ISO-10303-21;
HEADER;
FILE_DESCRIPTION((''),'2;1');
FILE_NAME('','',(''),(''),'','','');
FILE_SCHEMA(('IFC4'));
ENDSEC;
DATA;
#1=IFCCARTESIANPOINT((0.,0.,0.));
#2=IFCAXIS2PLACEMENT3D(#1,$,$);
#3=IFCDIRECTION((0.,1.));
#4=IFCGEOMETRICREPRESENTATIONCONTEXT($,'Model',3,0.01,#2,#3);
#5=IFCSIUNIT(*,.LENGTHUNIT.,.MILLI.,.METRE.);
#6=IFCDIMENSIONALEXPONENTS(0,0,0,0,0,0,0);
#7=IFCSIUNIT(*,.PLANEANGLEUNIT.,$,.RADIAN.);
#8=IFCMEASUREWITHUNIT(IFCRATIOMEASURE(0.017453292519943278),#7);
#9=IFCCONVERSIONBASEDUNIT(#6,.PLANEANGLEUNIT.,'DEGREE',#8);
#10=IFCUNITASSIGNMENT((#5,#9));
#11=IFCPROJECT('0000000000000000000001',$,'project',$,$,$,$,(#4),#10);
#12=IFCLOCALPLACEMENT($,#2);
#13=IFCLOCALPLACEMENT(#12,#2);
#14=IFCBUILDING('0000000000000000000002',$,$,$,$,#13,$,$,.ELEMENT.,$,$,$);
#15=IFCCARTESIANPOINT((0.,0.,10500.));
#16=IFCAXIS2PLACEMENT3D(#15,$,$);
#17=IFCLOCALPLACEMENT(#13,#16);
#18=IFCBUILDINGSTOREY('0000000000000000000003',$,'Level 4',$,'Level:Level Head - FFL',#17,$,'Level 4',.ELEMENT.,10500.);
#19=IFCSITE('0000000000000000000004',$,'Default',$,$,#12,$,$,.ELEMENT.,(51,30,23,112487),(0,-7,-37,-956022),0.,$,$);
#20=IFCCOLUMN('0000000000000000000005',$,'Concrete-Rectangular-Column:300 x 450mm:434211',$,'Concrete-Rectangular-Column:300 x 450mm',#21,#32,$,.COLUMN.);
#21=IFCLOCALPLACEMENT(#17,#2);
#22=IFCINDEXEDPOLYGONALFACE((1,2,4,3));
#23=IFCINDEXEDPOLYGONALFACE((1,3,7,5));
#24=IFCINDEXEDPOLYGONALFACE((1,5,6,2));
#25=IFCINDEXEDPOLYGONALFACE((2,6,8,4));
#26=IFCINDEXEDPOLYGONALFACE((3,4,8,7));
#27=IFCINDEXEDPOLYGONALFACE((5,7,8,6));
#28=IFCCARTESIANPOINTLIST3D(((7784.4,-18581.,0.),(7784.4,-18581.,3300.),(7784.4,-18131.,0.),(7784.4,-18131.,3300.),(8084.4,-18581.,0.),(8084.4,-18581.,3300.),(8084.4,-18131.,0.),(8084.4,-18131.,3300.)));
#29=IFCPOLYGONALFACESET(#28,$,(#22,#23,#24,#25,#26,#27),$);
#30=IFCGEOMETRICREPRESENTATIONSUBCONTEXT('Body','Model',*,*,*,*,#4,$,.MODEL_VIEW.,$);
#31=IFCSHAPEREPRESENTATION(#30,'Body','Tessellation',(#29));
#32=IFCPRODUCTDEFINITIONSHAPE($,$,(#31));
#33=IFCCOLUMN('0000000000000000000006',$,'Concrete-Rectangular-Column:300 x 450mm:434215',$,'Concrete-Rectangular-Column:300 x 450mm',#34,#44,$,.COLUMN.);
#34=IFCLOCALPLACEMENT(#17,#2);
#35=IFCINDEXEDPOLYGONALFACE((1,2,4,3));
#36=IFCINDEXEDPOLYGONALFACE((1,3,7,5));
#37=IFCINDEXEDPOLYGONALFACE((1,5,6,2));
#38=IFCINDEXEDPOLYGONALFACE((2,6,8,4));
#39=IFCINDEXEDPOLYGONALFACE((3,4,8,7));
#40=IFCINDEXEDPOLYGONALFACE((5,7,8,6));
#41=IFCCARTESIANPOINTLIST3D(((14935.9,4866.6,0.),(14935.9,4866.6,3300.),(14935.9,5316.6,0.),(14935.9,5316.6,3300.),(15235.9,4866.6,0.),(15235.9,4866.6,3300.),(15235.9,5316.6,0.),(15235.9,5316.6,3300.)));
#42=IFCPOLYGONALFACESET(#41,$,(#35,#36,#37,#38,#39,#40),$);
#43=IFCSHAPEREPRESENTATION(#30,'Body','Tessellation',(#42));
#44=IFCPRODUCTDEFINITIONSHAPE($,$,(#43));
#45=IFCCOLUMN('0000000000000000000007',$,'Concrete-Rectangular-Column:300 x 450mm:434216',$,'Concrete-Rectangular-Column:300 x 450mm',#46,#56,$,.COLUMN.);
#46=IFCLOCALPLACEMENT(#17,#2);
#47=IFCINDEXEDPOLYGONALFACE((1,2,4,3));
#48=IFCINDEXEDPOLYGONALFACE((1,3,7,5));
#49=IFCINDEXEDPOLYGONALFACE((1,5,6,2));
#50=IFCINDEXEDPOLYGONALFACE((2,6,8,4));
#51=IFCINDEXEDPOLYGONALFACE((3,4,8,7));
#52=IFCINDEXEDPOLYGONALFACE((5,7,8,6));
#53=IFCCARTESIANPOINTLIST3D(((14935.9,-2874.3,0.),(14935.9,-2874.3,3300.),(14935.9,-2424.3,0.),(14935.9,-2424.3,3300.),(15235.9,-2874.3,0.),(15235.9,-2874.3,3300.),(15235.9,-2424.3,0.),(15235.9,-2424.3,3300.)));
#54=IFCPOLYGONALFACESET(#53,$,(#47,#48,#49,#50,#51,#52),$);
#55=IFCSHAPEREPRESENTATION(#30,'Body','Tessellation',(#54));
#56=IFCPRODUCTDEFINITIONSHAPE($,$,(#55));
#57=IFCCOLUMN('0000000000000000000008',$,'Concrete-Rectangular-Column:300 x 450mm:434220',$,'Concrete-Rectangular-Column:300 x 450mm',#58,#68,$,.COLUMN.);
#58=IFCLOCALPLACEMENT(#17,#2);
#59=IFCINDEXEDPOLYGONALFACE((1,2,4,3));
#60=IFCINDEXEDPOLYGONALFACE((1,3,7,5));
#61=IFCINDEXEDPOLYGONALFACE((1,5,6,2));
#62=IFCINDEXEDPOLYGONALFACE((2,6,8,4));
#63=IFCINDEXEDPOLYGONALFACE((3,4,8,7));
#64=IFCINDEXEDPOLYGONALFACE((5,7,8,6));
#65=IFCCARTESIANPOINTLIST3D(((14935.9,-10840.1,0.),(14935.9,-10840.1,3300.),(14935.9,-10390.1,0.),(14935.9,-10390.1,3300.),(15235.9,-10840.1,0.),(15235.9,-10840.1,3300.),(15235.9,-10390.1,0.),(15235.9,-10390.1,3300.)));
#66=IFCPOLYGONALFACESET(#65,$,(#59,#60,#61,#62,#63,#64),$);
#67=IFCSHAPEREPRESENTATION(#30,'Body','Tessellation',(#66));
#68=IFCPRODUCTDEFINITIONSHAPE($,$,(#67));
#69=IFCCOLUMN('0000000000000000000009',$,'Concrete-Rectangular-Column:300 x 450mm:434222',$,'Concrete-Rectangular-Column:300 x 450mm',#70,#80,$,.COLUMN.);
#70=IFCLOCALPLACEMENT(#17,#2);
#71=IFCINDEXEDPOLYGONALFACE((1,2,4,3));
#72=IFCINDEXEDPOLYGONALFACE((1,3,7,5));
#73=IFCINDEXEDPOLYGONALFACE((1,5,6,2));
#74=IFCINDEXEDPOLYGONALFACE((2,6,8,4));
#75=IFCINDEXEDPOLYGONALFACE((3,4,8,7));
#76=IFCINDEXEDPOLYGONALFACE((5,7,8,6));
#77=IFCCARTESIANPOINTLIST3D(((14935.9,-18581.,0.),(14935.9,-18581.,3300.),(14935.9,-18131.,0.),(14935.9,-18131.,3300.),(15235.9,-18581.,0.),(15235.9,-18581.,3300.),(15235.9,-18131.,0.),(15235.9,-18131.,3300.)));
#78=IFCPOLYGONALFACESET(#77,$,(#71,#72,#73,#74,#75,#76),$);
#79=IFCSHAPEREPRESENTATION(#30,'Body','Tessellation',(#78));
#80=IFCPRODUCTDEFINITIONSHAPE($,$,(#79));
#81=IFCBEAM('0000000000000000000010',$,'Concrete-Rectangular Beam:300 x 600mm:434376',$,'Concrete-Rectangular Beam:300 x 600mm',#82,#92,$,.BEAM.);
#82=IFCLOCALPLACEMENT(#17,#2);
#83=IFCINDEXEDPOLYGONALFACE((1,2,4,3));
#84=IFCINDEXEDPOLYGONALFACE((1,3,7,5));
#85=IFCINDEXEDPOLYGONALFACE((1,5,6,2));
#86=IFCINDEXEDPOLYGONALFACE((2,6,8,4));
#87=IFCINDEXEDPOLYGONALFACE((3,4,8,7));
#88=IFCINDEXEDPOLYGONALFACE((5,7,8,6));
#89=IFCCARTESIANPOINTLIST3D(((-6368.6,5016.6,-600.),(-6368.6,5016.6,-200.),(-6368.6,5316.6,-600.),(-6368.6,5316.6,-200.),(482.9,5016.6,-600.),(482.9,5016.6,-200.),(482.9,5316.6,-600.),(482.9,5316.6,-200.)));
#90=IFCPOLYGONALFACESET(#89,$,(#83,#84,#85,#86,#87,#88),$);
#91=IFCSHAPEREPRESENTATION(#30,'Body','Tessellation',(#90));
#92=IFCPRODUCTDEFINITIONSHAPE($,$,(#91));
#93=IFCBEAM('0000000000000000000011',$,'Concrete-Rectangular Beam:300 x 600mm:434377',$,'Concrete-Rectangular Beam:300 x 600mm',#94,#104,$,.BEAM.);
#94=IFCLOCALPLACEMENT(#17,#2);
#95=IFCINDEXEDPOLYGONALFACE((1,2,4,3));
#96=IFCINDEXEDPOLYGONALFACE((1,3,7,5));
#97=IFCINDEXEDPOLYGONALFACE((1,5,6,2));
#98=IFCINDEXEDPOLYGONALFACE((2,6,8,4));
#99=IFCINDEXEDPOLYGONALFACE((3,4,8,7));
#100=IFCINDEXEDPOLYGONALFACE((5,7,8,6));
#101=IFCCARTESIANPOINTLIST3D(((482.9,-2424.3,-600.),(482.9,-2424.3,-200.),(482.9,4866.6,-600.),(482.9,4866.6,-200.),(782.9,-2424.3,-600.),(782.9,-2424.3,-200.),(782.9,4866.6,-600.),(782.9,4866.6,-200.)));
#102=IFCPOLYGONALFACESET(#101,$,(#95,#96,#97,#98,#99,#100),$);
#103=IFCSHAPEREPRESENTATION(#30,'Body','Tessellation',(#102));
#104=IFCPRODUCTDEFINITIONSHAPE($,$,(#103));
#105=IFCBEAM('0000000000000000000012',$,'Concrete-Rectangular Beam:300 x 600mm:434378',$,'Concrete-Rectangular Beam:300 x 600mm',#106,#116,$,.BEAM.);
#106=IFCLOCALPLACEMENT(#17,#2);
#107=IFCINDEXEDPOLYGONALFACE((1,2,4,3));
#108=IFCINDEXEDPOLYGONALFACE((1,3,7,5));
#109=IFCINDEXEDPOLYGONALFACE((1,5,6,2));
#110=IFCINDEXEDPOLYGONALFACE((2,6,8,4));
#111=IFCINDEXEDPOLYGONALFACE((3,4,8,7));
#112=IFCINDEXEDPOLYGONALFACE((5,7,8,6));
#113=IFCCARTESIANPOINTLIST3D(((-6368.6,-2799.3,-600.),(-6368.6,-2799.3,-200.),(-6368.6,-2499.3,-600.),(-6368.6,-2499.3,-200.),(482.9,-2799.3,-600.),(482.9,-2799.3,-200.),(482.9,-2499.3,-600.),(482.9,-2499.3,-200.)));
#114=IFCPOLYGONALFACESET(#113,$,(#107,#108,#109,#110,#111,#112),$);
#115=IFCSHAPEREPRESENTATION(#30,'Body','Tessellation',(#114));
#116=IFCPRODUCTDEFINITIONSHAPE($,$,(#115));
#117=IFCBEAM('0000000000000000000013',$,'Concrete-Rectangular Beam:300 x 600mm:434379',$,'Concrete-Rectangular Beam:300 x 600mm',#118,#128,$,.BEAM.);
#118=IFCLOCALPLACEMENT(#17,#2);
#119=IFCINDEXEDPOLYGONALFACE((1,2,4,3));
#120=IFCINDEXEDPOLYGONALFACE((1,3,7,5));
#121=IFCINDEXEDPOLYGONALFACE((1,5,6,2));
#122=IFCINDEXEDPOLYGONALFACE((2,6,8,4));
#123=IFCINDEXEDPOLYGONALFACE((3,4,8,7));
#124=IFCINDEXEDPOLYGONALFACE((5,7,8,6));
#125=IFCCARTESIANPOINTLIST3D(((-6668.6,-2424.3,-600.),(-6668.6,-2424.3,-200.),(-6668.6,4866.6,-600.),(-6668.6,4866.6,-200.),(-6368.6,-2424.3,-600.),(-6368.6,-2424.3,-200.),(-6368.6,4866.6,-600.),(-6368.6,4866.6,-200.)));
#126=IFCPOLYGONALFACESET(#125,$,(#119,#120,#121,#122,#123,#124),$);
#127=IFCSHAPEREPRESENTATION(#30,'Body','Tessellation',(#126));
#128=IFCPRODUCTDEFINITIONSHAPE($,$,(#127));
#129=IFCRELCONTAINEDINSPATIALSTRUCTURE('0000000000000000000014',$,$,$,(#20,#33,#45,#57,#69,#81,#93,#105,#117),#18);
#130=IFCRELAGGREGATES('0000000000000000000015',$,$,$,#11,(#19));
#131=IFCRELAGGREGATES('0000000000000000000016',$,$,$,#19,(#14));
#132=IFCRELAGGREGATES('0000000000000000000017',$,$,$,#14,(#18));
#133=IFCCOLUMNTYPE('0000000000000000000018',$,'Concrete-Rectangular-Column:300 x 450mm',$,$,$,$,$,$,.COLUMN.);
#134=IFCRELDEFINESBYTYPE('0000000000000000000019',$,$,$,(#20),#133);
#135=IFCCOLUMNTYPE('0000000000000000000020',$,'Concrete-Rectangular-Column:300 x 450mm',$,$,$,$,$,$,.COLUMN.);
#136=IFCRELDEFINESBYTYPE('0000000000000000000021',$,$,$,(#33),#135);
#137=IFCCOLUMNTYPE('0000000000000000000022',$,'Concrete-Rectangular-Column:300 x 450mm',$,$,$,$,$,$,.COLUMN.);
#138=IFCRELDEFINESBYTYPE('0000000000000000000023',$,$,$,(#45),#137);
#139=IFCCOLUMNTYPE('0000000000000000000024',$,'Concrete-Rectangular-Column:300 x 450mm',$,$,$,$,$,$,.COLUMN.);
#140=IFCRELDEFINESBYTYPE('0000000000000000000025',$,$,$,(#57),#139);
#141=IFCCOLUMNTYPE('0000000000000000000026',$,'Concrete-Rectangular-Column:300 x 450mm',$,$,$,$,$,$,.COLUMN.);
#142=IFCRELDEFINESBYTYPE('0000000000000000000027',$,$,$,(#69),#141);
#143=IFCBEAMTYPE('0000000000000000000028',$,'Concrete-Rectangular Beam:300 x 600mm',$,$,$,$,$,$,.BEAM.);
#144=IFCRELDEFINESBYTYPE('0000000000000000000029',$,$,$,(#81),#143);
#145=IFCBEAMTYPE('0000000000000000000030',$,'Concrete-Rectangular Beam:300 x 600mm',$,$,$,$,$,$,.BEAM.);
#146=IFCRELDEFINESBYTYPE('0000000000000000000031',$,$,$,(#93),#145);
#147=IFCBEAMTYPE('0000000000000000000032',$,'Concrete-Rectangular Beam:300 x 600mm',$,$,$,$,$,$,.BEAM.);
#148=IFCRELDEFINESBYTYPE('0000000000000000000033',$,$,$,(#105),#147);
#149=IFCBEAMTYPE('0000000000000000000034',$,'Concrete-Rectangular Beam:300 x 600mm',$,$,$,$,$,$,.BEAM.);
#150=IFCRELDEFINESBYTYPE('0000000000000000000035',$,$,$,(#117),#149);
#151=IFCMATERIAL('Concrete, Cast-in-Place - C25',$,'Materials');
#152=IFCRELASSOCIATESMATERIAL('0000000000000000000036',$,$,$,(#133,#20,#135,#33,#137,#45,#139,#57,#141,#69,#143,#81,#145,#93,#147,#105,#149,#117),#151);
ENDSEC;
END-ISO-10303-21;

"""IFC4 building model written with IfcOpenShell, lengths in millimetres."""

from ifc_helpers import new_model, entity, si_unit, converted_unit, direction, frame, origin, place, context, subcontext, project, spatial, indexed_curve, outline, extrude, source, transform, mapped, material, type_object, type_shapes, element, save


model = new_model("IFC4")

# Units and contexts
model_context = context("Model", 3, precision=0.01, world=origin(), true_north=direction((0.0, 1.0)))
body_context = subcontext(model_context, "Body", "Model", "MODEL_VIEW")
ifc_project = project(units=[si_unit("LENGTHUNIT", "METRE", prefix="MILLI"), converted_unit("PLANEANGLEUNIT", "DEGREE", entity("IfcRatioMeasure", 0.017453292519943278), si_unit("PLANEANGLEUNIT", "RADIAN"), dimensions=[0, 0, 0, 0, 0, 0, 0])], contexts=[model_context])

# Site, building, storey
site_placement = place(None, origin())
site = spatial("IfcSite", under=ifc_project, at=site_placement, Name="Default", CompositionType="ELEMENT", RefLatitude=(51, 30, 23, 112487), RefLongitude=(0, -7, -37, -956022), RefElevation=0.0)
building_placement = place(site_placement, origin())
building = spatial("IfcBuilding", under=site, at=building_placement, CompositionType="ELEMENT")
storey_placement = place(building_placement, frame((0.0, 0.0, 10500.0)))
storey = spatial("IfcBuildingStorey", under=building, at=storey_placement, Name="Level 4", ObjectType="Level:Level Head - FFL", LongName="Level 4", CompositionType="ELEMENT", Elevation=10500.0)

# Columns
ifc_material = material(Name="Concrete, Cast-in-Place - C25", Category="Materials")
column_type_1 = type_object("IfcColumnType", Name="Concrete-Rectangular-Column:300 x 450mm", PredefinedType="COLUMN", material=ifc_material)
shared_shape_1 = source(origin(), body_context, "Body", "SweptSolid", [
    extrude(outline(indexed_curve([(-225.0, -150.0), (225.0, -150.0), (225.0, 150.0), (-225.0, 150.0), (-225.0, -150.0)], self_intersect=False)), frame((7934.4, -18356.0, 10500.0), z_axis=(0.0, 0.0, 1.0), x_axis=(0.0, -1.0, 0.0)), (0.0, 0.0, 1.0), 3300.0),
])
type_shapes(column_type_1, [shared_shape_1])
column_1_placement = place(storey_placement, frame((0.0, 0.0, -10500.0)))
element("IfcColumn", 1, at=column_1_placement, inside=storey, type_object=column_type_1, material=ifc_material, Name="Concrete-Rectangular-Column:300 x 450mm:434211", ObjectType="Concrete-Rectangular-Column:300 x 450mm", PredefinedType="COLUMN", context=body_context, shape_type="MappedRepresentation", body=[
    mapped(shared_shape_1, transform((0.0, 0.0, 0.0), scale=1.0)),
])
column_type_2 = type_object("IfcColumnType", Name="Concrete-Rectangular-Column:300 x 450mm", PredefinedType="COLUMN", material=ifc_material)
shared_shape_2 = source(origin(), body_context, "Body", "SweptSolid", [
    extrude(outline(indexed_curve([(-225.0, -150.0), (225.0, -150.0), (225.0, 150.0), (-225.0, 150.0), (-225.0, -150.0)], self_intersect=False)), frame((15085.9, 5091.6, 10500.0), z_axis=(0.0, 0.0, 1.0), x_axis=(0.0, -1.0, 0.0)), (0.0, 0.0, 1.0), 3300.0),
])
type_shapes(column_type_2, [shared_shape_2])
column_2_placement = place(storey_placement, frame((0.0, 0.0, -10500.0)))
element("IfcColumn", 2, at=column_2_placement, inside=storey, type_object=column_type_2, material=ifc_material, Name="Concrete-Rectangular-Column:300 x 450mm:434215", ObjectType="Concrete-Rectangular-Column:300 x 450mm", PredefinedType="COLUMN", context=body_context, shape_type="MappedRepresentation", body=[
    mapped(shared_shape_2, transform((0.0, 0.0, 0.0), scale=1.0)),
])
column_type_3 = type_object("IfcColumnType", Name="Concrete-Rectangular-Column:300 x 450mm", PredefinedType="COLUMN", material=ifc_material)
shared_shape_3 = source(origin(), body_context, "Body", "SweptSolid", [
    extrude(outline(indexed_curve([(-225.0, -150.0), (225.0, -150.0), (225.0, 150.0), (-225.0, 150.0), (-225.0, -150.0)], self_intersect=False)), frame((15085.9, -2649.3, 10500.0), z_axis=(0.0, 0.0, 1.0), x_axis=(0.0, -1.0, 0.0)), (0.0, 0.0, 1.0), 3300.0),
])
type_shapes(column_type_3, [shared_shape_3])
column_3_placement = place(storey_placement, frame((0.0, 0.0, -10500.0)))
element("IfcColumn", 3, at=column_3_placement, inside=storey, type_object=column_type_3, material=ifc_material, Name="Concrete-Rectangular-Column:300 x 450mm:434216", ObjectType="Concrete-Rectangular-Column:300 x 450mm", PredefinedType="COLUMN", context=body_context, shape_type="MappedRepresentation", body=[
    mapped(shared_shape_3, transform((0.0, 0.0, 0.0), scale=1.0)),
])
column_type_4 = type_object("IfcColumnType", Name="Concrete-Rectangular-Column:300 x 450mm", PredefinedType="COLUMN", material=ifc_material)
shared_shape_4 = source(origin(), body_context, "Body", "SweptSolid", [
    extrude(outline(indexed_curve([(-225.0, -150.0), (225.0, -150.0), (225.0, 150.0), (-225.0, 150.0), (-225.0, -150.0)], self_intersect=False)), frame((15085.9, -10615.1, 10500.0), z_axis=(0.0, 0.0, 1.0), x_axis=(0.0, -1.0, 0.0)), (0.0, 0.0, 1.0), 3300.0),
])
type_shapes(column_type_4, [shared_shape_4])
column_4_placement = place(storey_placement, frame((0.0, 0.0, -10500.0)))
element("IfcColumn", 4, at=column_4_placement, inside=storey, type_object=column_type_4, material=ifc_material, Name="Concrete-Rectangular-Column:300 x 450mm:434220", ObjectType="Concrete-Rectangular-Column:300 x 450mm", PredefinedType="COLUMN", context=body_context, shape_type="MappedRepresentation", body=[
    mapped(shared_shape_4, transform((0.0, 0.0, 0.0), scale=1.0)),
])
column_type_5 = type_object("IfcColumnType", Name="Concrete-Rectangular-Column:300 x 450mm", PredefinedType="COLUMN", material=ifc_material)
shared_shape_5 = source(origin(), body_context, "Body", "SweptSolid", [
    extrude(outline(indexed_curve([(-225.0, -150.0), (225.0, -150.0), (225.0, 150.0), (-225.0, 150.0), (-225.0, -150.0)], self_intersect=False)), frame((15085.9, -18356.0, 10500.0), z_axis=(0.0, 0.0, 1.0), x_axis=(0.0, -1.0, 0.0)), (0.0, 0.0, 1.0), 3300.0),
])
type_shapes(column_type_5, [shared_shape_5])
column_5_placement = place(storey_placement, frame((0.0, 0.0, -10500.0)))
element("IfcColumn", 5, at=column_5_placement, inside=storey, type_object=column_type_5, material=ifc_material, Name="Concrete-Rectangular-Column:300 x 450mm:434222", ObjectType="Concrete-Rectangular-Column:300 x 450mm", PredefinedType="COLUMN", context=body_context, shape_type="MappedRepresentation", body=[
    mapped(shared_shape_5, transform((0.0, 0.0, 0.0), scale=1.0)),
])

# Beams
beam_type_1 = type_object("IfcBeamType", Name="Concrete-Rectangular Beam:300 x 600mm", PredefinedType="BEAM", material=ifc_material)
shared_shape_6 = source(origin(), body_context, "Body", "SweptSolid", [
    extrude(outline(indexed_curve([(-200.0, -150.0), (200.0, -150.0), (200.0, 150.0), (-200.0, 150.0), (-200.0, -150.0)], self_intersect=False)), frame((-6368.6, 5166.6, 10100.0), z_axis=(1.0, 0.0, 0.0), x_axis=(0.0, 0.0, -1.0)), (0.0, 0.0, 1.0), 6851.5),
])
type_shapes(beam_type_1, [shared_shape_6])
beam_1_placement = place(storey_placement, frame((0.0, 0.0, -10500.0)))
element("IfcBeam", 6, at=beam_1_placement, inside=storey, type_object=beam_type_1, material=ifc_material, Name="Concrete-Rectangular Beam:300 x 600mm:434376", ObjectType="Concrete-Rectangular Beam:300 x 600mm", PredefinedType="BEAM", context=body_context, shape_type="MappedRepresentation", body=[
    mapped(shared_shape_6, transform((0.0, 0.0, 0.0), scale=1.0)),
])
beam_type_2 = type_object("IfcBeamType", Name="Concrete-Rectangular Beam:300 x 600mm", PredefinedType="BEAM", material=ifc_material)
shared_shape_7 = source(origin(), body_context, "Body", "SweptSolid", [
    extrude(outline(indexed_curve([(-150.0, -200.0), (150.0, -200.0), (150.0, 200.0), (-150.0, 200.0), (-150.0, -200.0)], self_intersect=False)), frame((632.9, 4866.6, 10100.0), z_axis=(0.0, -1.0, 0.0), x_axis=(-1.0, 0.0, 0.0)), (0.0, 0.0, 1.0), 7290.9),
])
type_shapes(beam_type_2, [shared_shape_7])
beam_2_placement = place(storey_placement, frame((0.0, 0.0, -10500.0)))
element("IfcBeam", 7, at=beam_2_placement, inside=storey, type_object=beam_type_2, material=ifc_material, Name="Concrete-Rectangular Beam:300 x 600mm:434377", ObjectType="Concrete-Rectangular Beam:300 x 600mm", PredefinedType="BEAM", context=body_context, shape_type="MappedRepresentation", body=[
    mapped(shared_shape_7, transform((0.0, 0.0, 0.0), scale=1.0)),
])
beam_type_3 = type_object("IfcBeamType", Name="Concrete-Rectangular Beam:300 x 600mm", PredefinedType="BEAM", material=ifc_material)
shared_shape_8 = source(origin(), body_context, "Body", "SweptSolid", [
    extrude(outline(indexed_curve([(-200.0, -150.0), (200.0, -150.0), (200.0, 150.0), (-200.0, 150.0), (-200.0, -150.0)], self_intersect=False)), frame((482.9, -2649.3, 10100.0), z_axis=(-1.0, 0.0, 0.0), x_axis=(0.0, 0.0, -1.0)), (0.0, 0.0, 1.0), 6851.5),
])
type_shapes(beam_type_3, [shared_shape_8])
beam_3_placement = place(storey_placement, frame((0.0, 0.0, -10500.0)))
element("IfcBeam", 8, at=beam_3_placement, inside=storey, type_object=beam_type_3, material=ifc_material, Name="Concrete-Rectangular Beam:300 x 600mm:434378", ObjectType="Concrete-Rectangular Beam:300 x 600mm", PredefinedType="BEAM", context=body_context, shape_type="MappedRepresentation", body=[
    mapped(shared_shape_8, transform((0.0, 0.0, 0.0), scale=1.0)),
])
beam_type_4 = type_object("IfcBeamType", Name="Concrete-Rectangular Beam:300 x 600mm", PredefinedType="BEAM", material=ifc_material)
shared_shape_9 = source(origin(), body_context, "Body", "SweptSolid", [
    extrude(outline(indexed_curve([(-150.0, -200.0), (150.0, -200.0), (150.0, 200.0), (-150.0, 200.0), (-150.0, -200.0)], self_intersect=False)), frame((-6518.6, -2424.3, 10100.0), z_axis=(0.0, 1.0, 0.0), x_axis=(-1.0, 0.0, 0.0)), (0.0, 0.0, 1.0), 7290.9),
])
type_shapes(beam_type_4, [shared_shape_9])
beam_4_placement = place(storey_placement, frame((0.0, 0.0, -10500.0)))
element("IfcBeam", 9, at=beam_4_placement, inside=storey, type_object=beam_type_4, material=ifc_material, Name="Concrete-Rectangular Beam:300 x 600mm:434379", ObjectType="Concrete-Rectangular Beam:300 x 600mm", PredefinedType="BEAM", context=body_context, shape_type="MappedRepresentation", body=[
    mapped(shared_shape_9, transform((0.0, 0.0, 0.0), scale=1.0)),
])

save(model, "model.ifc")
